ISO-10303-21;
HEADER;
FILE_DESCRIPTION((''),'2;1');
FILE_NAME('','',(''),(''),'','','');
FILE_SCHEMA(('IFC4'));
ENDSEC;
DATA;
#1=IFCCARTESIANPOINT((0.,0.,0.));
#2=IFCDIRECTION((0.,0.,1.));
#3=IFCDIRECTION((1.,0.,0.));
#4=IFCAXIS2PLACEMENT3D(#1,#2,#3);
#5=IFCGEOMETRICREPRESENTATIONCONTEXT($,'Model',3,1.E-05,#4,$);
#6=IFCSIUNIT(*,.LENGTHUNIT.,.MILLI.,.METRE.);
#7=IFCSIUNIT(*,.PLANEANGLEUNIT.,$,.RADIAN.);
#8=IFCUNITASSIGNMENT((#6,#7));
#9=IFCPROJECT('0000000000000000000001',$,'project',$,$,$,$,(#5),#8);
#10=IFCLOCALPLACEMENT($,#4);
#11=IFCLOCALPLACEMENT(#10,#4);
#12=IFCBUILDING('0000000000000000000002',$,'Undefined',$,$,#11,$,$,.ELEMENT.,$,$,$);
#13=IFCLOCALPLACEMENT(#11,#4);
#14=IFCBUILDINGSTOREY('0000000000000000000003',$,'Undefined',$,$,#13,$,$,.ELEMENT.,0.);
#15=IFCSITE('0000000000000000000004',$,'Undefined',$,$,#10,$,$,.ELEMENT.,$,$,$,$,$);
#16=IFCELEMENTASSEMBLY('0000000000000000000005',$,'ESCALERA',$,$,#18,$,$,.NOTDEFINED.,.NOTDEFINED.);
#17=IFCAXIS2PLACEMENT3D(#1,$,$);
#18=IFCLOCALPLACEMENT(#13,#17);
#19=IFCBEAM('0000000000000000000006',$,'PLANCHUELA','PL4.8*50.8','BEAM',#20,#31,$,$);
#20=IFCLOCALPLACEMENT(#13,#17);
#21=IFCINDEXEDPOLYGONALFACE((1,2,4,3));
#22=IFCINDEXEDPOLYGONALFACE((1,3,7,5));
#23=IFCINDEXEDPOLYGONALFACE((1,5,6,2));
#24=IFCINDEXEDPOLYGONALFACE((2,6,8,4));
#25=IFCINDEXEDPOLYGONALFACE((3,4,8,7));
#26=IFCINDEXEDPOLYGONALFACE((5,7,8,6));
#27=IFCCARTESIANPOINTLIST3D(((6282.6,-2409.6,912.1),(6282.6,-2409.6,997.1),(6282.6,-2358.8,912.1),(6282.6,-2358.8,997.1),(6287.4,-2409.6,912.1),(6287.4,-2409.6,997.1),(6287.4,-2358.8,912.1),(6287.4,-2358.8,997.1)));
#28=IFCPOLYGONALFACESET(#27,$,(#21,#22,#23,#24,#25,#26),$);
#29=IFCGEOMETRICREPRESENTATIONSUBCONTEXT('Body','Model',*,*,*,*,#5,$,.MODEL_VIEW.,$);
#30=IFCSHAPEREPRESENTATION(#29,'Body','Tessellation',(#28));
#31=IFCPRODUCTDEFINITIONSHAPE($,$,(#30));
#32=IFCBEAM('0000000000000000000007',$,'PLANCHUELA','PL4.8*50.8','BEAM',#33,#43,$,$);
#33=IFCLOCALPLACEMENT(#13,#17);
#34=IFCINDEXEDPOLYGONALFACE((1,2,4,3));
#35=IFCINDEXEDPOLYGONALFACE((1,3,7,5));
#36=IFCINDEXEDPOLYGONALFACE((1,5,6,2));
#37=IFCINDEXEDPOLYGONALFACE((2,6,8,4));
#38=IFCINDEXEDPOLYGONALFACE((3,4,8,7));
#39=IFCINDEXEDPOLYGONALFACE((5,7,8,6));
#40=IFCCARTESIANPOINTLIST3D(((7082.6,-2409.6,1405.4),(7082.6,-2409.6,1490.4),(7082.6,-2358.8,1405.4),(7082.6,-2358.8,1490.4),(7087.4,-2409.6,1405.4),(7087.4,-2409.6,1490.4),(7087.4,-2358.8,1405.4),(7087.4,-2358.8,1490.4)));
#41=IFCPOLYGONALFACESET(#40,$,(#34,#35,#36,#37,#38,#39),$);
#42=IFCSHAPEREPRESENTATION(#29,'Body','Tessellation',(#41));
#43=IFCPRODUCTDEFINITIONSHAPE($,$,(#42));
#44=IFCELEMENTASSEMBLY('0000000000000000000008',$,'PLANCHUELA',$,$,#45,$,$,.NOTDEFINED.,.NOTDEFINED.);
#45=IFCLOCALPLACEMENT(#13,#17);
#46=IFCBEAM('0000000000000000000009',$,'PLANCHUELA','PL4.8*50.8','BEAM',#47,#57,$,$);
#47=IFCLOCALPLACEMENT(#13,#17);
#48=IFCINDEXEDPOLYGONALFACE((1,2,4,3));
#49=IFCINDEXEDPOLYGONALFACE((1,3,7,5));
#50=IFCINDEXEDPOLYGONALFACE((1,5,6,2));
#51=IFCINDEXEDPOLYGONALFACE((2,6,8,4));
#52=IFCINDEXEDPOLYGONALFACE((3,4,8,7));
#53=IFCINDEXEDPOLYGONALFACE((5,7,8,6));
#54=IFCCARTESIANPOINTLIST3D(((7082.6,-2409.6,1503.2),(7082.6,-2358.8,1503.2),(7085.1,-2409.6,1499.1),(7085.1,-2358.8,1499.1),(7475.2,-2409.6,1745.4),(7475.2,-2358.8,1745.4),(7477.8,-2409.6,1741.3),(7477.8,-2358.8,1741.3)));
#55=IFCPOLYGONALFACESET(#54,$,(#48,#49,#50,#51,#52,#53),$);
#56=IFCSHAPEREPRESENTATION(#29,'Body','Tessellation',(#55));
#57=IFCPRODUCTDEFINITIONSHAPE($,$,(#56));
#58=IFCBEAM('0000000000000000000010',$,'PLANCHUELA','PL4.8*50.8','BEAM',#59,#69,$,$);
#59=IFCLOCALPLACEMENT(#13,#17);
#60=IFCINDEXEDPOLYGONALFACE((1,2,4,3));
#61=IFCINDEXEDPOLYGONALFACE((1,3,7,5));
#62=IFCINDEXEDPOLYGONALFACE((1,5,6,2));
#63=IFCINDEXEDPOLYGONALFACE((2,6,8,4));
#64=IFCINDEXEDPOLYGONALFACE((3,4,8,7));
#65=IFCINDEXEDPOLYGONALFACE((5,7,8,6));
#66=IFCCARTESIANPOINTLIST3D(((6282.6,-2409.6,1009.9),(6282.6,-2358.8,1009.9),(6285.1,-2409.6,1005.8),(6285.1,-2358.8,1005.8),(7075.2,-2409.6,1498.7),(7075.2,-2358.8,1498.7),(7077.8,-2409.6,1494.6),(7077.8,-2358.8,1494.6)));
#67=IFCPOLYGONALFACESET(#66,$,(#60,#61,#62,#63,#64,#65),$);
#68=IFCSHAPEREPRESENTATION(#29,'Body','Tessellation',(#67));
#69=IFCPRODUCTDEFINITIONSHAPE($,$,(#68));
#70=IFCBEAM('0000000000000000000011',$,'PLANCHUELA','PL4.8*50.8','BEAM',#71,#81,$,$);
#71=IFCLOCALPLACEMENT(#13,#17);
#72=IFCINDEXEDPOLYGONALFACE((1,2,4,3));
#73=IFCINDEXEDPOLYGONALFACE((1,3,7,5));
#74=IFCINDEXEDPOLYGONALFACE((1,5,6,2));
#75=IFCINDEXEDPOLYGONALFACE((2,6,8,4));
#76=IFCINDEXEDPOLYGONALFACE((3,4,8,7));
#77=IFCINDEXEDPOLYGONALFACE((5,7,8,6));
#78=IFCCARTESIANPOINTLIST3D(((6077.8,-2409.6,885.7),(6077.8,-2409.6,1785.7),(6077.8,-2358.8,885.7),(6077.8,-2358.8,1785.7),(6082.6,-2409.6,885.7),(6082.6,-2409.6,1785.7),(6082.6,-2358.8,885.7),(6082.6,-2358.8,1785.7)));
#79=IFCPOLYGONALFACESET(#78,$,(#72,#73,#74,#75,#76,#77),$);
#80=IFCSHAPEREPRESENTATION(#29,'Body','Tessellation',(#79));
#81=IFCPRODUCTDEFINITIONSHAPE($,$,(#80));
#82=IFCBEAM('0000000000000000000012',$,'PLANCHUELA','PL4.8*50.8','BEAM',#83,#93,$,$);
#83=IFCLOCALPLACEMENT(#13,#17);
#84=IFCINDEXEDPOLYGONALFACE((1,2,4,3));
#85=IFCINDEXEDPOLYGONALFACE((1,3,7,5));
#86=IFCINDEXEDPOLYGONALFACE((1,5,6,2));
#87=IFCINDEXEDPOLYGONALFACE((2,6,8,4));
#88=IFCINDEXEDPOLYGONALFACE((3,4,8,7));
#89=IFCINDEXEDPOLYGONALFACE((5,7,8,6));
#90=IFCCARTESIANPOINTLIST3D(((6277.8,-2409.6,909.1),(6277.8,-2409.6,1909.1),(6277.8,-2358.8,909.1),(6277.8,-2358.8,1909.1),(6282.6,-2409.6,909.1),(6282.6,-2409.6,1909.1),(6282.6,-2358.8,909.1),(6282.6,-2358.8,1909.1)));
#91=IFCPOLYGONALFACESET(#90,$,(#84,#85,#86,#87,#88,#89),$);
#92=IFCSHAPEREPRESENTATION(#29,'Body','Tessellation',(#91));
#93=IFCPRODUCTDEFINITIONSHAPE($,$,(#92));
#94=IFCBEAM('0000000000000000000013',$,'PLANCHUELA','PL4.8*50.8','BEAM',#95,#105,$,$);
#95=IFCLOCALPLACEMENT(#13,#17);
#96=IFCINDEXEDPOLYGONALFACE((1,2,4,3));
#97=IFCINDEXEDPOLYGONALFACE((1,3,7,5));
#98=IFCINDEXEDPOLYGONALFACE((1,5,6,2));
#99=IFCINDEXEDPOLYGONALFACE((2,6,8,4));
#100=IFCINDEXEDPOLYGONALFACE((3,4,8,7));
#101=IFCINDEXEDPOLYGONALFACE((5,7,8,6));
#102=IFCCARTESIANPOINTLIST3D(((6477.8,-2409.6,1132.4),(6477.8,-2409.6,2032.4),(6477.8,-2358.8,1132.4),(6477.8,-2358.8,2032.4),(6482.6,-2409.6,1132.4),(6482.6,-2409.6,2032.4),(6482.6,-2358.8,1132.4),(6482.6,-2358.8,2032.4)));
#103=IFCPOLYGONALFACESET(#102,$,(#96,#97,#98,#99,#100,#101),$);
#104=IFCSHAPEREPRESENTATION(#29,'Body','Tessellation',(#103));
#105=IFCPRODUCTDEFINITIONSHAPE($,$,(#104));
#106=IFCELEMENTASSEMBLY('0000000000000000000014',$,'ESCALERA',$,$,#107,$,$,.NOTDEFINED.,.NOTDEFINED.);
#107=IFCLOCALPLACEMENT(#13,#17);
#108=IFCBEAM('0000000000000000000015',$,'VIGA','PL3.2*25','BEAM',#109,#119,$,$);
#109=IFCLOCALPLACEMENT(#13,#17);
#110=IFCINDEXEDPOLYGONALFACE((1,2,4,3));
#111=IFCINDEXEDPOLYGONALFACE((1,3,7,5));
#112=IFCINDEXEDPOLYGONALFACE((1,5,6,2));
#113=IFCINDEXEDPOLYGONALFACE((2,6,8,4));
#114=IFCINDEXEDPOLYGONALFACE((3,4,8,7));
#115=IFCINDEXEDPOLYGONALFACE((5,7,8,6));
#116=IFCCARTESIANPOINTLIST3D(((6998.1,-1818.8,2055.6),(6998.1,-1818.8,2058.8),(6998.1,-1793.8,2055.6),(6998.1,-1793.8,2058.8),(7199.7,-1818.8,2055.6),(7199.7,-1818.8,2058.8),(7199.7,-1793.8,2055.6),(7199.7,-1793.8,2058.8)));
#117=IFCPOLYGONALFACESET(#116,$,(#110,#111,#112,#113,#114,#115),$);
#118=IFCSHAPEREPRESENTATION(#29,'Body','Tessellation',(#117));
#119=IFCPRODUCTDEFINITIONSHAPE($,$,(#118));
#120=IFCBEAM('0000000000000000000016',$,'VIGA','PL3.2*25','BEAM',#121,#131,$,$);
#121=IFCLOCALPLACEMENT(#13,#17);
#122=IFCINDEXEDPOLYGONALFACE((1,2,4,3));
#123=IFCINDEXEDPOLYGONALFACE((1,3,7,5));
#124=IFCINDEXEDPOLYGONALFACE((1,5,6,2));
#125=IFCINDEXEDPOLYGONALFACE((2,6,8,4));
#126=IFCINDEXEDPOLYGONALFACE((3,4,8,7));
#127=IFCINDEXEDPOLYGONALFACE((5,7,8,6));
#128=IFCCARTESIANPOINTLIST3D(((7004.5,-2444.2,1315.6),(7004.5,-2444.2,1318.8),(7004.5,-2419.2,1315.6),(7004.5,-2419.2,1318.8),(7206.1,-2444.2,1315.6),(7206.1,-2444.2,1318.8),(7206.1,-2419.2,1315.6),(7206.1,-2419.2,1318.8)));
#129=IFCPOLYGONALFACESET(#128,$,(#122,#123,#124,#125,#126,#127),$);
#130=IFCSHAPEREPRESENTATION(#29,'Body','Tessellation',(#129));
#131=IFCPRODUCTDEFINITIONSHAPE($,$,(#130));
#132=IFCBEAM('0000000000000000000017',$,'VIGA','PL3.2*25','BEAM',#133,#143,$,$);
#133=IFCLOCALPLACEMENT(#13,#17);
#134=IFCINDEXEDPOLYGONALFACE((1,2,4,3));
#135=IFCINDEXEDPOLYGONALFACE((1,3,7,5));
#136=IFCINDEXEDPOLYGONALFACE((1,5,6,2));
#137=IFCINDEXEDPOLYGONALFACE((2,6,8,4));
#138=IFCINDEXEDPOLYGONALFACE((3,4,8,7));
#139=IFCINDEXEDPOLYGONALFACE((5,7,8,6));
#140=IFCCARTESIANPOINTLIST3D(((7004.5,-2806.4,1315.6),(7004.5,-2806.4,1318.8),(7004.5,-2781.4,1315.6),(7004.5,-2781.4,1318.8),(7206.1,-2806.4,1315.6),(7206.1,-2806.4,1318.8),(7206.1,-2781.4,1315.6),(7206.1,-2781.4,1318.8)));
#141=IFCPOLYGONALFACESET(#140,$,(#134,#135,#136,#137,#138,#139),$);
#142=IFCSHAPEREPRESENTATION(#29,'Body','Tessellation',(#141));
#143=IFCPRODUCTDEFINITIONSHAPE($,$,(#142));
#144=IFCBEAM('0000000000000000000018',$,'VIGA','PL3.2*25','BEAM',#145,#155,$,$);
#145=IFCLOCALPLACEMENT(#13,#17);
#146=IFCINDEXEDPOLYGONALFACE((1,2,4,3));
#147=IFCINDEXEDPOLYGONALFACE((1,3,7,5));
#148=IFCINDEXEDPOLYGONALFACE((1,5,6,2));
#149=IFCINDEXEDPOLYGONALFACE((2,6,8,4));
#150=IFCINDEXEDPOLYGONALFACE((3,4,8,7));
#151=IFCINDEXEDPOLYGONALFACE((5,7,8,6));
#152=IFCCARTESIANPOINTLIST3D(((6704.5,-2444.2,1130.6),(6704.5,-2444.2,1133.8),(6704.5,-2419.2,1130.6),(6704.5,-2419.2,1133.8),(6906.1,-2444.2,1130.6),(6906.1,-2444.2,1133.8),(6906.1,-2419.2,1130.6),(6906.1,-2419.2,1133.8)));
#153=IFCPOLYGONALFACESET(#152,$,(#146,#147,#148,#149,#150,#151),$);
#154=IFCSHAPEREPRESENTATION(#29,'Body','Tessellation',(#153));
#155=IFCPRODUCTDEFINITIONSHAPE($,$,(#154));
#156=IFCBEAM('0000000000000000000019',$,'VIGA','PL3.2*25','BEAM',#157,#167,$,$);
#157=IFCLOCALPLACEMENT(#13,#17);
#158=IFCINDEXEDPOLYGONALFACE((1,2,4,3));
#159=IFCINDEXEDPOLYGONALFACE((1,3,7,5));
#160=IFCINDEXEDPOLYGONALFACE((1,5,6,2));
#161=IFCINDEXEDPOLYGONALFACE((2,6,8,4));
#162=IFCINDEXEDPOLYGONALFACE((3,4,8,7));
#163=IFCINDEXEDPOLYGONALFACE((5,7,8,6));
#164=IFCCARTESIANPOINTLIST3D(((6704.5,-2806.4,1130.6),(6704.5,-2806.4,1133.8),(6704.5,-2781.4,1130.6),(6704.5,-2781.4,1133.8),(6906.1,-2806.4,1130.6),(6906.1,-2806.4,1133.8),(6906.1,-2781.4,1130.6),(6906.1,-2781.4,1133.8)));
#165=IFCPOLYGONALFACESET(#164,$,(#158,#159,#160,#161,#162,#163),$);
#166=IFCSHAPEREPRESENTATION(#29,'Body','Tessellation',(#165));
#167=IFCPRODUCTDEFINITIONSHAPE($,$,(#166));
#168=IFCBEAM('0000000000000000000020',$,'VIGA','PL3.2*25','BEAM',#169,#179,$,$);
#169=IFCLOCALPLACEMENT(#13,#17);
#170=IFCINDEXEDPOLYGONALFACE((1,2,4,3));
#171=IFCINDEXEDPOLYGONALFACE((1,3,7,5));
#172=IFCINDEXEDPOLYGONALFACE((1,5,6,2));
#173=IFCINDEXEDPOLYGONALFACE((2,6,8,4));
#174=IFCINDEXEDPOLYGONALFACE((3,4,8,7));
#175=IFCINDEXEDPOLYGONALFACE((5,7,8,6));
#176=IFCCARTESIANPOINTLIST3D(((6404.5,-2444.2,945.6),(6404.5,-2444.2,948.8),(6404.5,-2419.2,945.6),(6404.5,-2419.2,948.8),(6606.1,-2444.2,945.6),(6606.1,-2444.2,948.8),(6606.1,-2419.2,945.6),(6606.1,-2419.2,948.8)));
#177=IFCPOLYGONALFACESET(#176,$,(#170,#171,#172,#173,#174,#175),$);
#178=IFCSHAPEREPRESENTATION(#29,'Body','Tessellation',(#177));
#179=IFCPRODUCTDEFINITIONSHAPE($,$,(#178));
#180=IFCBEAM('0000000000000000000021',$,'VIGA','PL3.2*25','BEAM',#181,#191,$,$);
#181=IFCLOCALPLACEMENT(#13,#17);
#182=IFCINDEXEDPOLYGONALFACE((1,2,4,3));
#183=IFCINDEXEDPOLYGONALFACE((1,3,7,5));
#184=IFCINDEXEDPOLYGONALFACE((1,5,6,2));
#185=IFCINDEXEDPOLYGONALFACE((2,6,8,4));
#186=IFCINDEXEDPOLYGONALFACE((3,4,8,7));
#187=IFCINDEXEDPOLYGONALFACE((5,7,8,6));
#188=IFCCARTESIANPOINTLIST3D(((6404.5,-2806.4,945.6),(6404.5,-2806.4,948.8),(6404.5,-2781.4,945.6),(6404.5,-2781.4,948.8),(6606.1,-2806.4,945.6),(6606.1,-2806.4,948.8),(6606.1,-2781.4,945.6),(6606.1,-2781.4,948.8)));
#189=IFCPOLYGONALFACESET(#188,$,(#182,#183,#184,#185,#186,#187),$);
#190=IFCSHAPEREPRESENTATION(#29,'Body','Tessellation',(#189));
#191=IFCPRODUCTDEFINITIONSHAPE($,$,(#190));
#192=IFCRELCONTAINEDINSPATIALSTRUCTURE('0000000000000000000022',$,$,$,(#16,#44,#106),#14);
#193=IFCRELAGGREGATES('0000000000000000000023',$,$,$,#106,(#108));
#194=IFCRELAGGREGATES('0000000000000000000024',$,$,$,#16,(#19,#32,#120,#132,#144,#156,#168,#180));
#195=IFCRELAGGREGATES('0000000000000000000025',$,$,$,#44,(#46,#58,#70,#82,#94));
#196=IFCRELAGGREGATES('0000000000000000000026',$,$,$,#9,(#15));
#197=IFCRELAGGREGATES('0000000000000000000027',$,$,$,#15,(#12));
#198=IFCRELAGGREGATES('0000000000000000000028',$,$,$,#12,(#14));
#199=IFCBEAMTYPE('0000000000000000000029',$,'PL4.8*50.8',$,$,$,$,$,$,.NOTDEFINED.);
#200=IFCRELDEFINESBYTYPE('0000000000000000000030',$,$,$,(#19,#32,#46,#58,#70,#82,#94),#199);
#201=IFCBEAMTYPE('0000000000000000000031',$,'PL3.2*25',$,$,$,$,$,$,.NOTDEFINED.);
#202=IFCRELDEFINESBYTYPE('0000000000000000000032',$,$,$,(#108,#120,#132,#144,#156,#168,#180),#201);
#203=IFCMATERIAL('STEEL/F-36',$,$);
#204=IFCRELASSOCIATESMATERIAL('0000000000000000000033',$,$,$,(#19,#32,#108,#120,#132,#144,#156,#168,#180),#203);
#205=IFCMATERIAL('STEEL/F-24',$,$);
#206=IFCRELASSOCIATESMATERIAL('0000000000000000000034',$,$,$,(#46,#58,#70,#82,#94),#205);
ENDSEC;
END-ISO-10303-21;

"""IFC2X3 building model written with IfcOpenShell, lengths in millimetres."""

from ifc_helpers import new_model, si_unit, frame, origin_with_axes, origin_2d_with_axis, place, context, subcontext, project, spatial, rectangle, extrude, material, type_object, element, aggregate, save


model = new_model("IFC2X3")

# Units and contexts
model_context = context("Model", 3, precision=1e-05, world=origin_with_axes())
body_context = subcontext(model_context, "Body", "Model", "MODEL_VIEW")
ifc_project = project(units=[si_unit("LENGTHUNIT", "METRE", prefix="MILLI"), si_unit("PLANEANGLEUNIT", "RADIAN")], contexts=[model_context])

# Site, building, storey
site_placement = place(None, origin_with_axes())
site = spatial("IfcSite", under=ifc_project, at=site_placement, Name="Undefined", CompositionType="ELEMENT")
building_placement = place(site_placement, origin_with_axes())
building = spatial("IfcBuilding", under=site, at=building_placement, Name="Undefined", CompositionType="ELEMENT")
storey_placement = place(building_placement, origin_with_axes())
storey = spatial("IfcBuildingStorey", under=building, at=storey_placement, Name="Undefined", CompositionType="ELEMENT", Elevation=0.0)

# Element assemblies, beams
assembly_1_placement = place(storey_placement, origin_with_axes())
assembly_1 = element("IfcElementAssembly", 1, at=assembly_1_placement, inside=storey, Name="ESCALERA", AssemblyPlace="NOTDEFINED", PredefinedType="NOTDEFINED")
ifc_material_1 = material(Name="STEEL/F-36")
beam_type_1 = type_object("IfcBeamType", Name="PL4.8*50.8", PredefinedType="NOTDEFINED")
beam_1_placement = place(assembly_1_placement, frame((6285.0, -2384.2, 997.1), z_axis=(0.0, -1.0, 0.0), x_axis=(0.0, 0.0, -1.0)))
beam_1 = element("IfcBeam", 2, at=beam_1_placement, type_object=beam_type_1, material=ifc_material_1, Name="PLANCHUELA", Description="PL4.8*50.8", ObjectType="BEAM", context=body_context, shape_type="SweptSolid", body=[
    extrude(rectangle(XDim=4.8, YDim=50.8, at=origin_2d_with_axis()), frame((85.0, 0.0, 0.0), z_axis=(-1.0, 0.0, 0.0), x_axis=(0.0, -1.0, 0.0)), (0.0, 0.0, 1.0), 85.0),
])
beam_2_placement = place(assembly_1_placement, frame((7085.0, -2384.2, 1490.4), z_axis=(0.0, -1.0, 0.0), x_axis=(0.0, 0.0, -1.0)))
beam_2 = element("IfcBeam", 3, at=beam_2_placement, type_object=beam_type_1, material=ifc_material_1, Name="PLANCHUELA", Description="PL4.8*50.8", ObjectType="BEAM", context=body_context, shape_type="SweptSolid", body=[
    extrude(rectangle(XDim=4.8, YDim=50.8, at=origin_2d_with_axis()), frame((85.0, 0.0, 0.0), z_axis=(-1.0, 0.0, 0.0), x_axis=(0.0, -1.0, 0.0)), (0.0, 0.0, 1.0), 85.0),
])
assembly_2_placement = place(storey_placement, origin_with_axes())
assembly_2 = element("IfcElementAssembly", 4, at=assembly_2_placement, inside=storey, Name="PLANCHUELA", AssemblyPlace="NOTDEFINED", PredefinedType="NOTDEFINED")
ifc_material_2 = material(Name="STEEL/F-24")
beam_3_placement = place(assembly_2_placement, frame((7083.8, -2384.2, 1501.2), z_axis=(0.0, -1.0, 0.0), x_axis=(0.85117, 0.0, 0.52489)))
beam_3 = element("IfcBeam", 5, at=beam_3_placement, type_object=beam_type_1, material=ifc_material_2, Name="PLANCHUELA", Description="PL4.8*50.8", ObjectType="BEAM", context=body_context, shape_type="SweptSolid", body=[
    extrude(rectangle(XDim=4.8, YDim=50.8, at=origin_2d_with_axis()), frame((461.3, 0.0, 0.0), z_axis=(-1.0, 0.0, 0.0), x_axis=(0.0, -1.0, 0.0)), (0.0, 0.0, 1.0), 461.3),
])
beam_4_placement = place(assembly_2_placement, frame((6283.8, -2384.2, 1007.9), z_axis=(0.0, -1.0, 0.0), x_axis=(0.85117, 0.0, 0.52489)))
beam_4 = element("IfcBeam", 6, at=beam_4_placement, type_object=beam_type_1, material=ifc_material_2, Name="PLANCHUELA", Description="PL4.8*50.8", ObjectType="BEAM", context=body_context, shape_type="SweptSolid", body=[
    extrude(rectangle(XDim=4.8, YDim=50.8, at=origin_2d_with_axis()), frame((931.3, 0.0, 0.0), z_axis=(-1.0, 0.0, 0.0), x_axis=(0.0, -1.0, 0.0)), (0.0, 0.0, 1.0), 931.3),
])
beam_5_placement = place(assembly_2_placement, frame((6080.2, -2384.2, 1785.7), z_axis=(0.0, -1.0, 0.0), x_axis=(0.0, 0.0, -1.0)))
beam_5 = element("IfcBeam", 7, at=beam_5_placement, type_object=beam_type_1, material=ifc_material_2, Name="PLANCHUELA", Description="PL4.8*50.8", ObjectType="BEAM", context=body_context, shape_type="SweptSolid", body=[
    extrude(rectangle(XDim=4.8, YDim=50.8, at=origin_2d_with_axis()), frame((900.0, 0.0, 0.0), z_axis=(-1.0, 0.0, 0.0), x_axis=(0.0, -1.0, 0.0)), (0.0, 0.0, 1.0), 900.0),
])
beam_6_placement = place(assembly_2_placement, frame((6280.2, -2384.2, 1909.1), z_axis=(0.0, -1.0, 0.0), x_axis=(0.0, 0.0, -1.0)))
beam_6 = element("IfcBeam", 8, at=beam_6_placement, type_object=beam_type_1, material=ifc_material_2, Name="PLANCHUELA", Description="PL4.8*50.8", ObjectType="BEAM", context=body_context, shape_type="SweptSolid", body=[
    extrude(rectangle(XDim=4.8, YDim=50.8, at=origin_2d_with_axis()), frame((1000.0, 0.0, 0.0), z_axis=(-1.0, 0.0, 0.0), x_axis=(0.0, -1.0, 0.0)), (0.0, 0.0, 1.0), 1000.0),
])
beam_7_placement = place(assembly_2_placement, frame((6480.2, -2384.2, 2032.4), z_axis=(0.0, -1.0, 0.0), x_axis=(0.0, 0.0, -1.0)))
beam_7 = element("IfcBeam", 9, at=beam_7_placement, type_object=beam_type_1, material=ifc_material_2, Name="PLANCHUELA", Description="PL4.8*50.8", ObjectType="BEAM", context=body_context, shape_type="SweptSolid", body=[
    extrude(rectangle(XDim=4.8, YDim=50.8, at=origin_2d_with_axis()), frame((900.0, 0.0, 0.0), z_axis=(-1.0, 0.0, 0.0), x_axis=(0.0, -1.0, 0.0)), (0.0, 0.0, 1.0), 900.0),
])

# Element assembly, beam
assembly_3_placement = place(storey_placement, origin_with_axes())
assembly_3 = element("IfcElementAssembly", 10, at=assembly_3_placement, inside=storey, Name="ESCALERA", AssemblyPlace="NOTDEFINED", PredefinedType="NOTDEFINED")
beam_type_2 = type_object("IfcBeamType", Name="PL3.2*25", PredefinedType="NOTDEFINED")
beam_8_placement = place(assembly_3_placement, frame((7199.7, -1806.3, 2057.2), z_axis=(0.0, 1.0, 0.0), x_axis=(-1.0, 0.0, 0.000012)))
beam_8 = element("IfcBeam", 11, at=beam_8_placement, type_object=beam_type_2, material=ifc_material_1, Name="VIGA", Description="PL3.2*25", ObjectType="BEAM", context=body_context, shape_type="SweptSolid", body=[
    extrude(rectangle(XDim=3.2, YDim=25.0, at=origin_2d_with_axis()), frame((201.6, 0.0, 0.0), z_axis=(-1.0, 0.0, 0.0), x_axis=(0.0, -1.0, 0.0)), (0.0, 0.0, 1.0), 201.6),
])

# Beams
beam_9_placement = place(assembly_1_placement, frame((7004.5, -2431.7, 1317.2), z_axis=(0.0, 1.0, 0.0), x_axis=(1.0, 0.0, 0.000012)))
beam_9 = element("IfcBeam", 12, at=beam_9_placement, type_object=beam_type_2, material=ifc_material_1, Name="VIGA", Description="PL3.2*25", ObjectType="BEAM", context=body_context, shape_type="SweptSolid", body=[
    extrude(rectangle(XDim=3.2, YDim=25.0, at=origin_2d_with_axis()), frame((201.6, 0.0, 0.0), z_axis=(-1.0, 0.0, 0.0), x_axis=(0.0, -1.0, 0.0)), (0.0, 0.0, 1.0), 201.6),
])
beam_10_placement = place(assembly_1_placement, frame((7004.5, -2793.9, 1317.2), z_axis=(0.0, 1.0, 0.0), x_axis=(1.0, 0.0, 0.000012)))
beam_10 = element("IfcBeam", 13, at=beam_10_placement, type_object=beam_type_2, material=ifc_material_1, Name="VIGA", Description="PL3.2*25", ObjectType="BEAM", context=body_context, shape_type="SweptSolid", body=[
    extrude(rectangle(XDim=3.2, YDim=25.0, at=origin_2d_with_axis()), frame((201.6, 0.0, 0.0), z_axis=(-1.0, 0.0, 0.0), x_axis=(0.0, -1.0, 0.0)), (0.0, 0.0, 1.0), 201.6),
])
beam_11_placement = place(assembly_1_placement, frame((6704.5, -2431.7, 1132.2), z_axis=(0.0, 1.0, 0.0), x_axis=(1.0, 0.0, 0.000012)))
beam_11 = element("IfcBeam", 14, at=beam_11_placement, type_object=beam_type_2, material=ifc_material_1, Name="VIGA", Description="PL3.2*25", ObjectType="BEAM", context=body_context, shape_type="SweptSolid", body=[
    extrude(rectangle(XDim=3.2, YDim=25.0, at=origin_2d_with_axis()), frame((201.6, 0.0, 0.0), z_axis=(-1.0, 0.0, 0.0), x_axis=(0.0, -1.0, 0.0)), (0.0, 0.0, 1.0), 201.6),
])
beam_12_placement = place(assembly_1_placement, frame((6704.5, -2793.9, 1132.2), z_axis=(0.0, 1.0, 0.0), x_axis=(1.0, 0.0, 0.000012)))
beam_12 = element("IfcBeam", 15, at=beam_12_placement, type_object=beam_type_2, material=ifc_material_1, Name="VIGA", Description="PL3.2*25", ObjectType="BEAM", context=body_context, shape_type="SweptSolid", body=[
    extrude(rectangle(XDim=3.2, YDim=25.0, at=origin_2d_with_axis()), frame((201.6, 0.0, 0.0), z_axis=(-1.0, 0.0, 0.0), x_axis=(0.0, -1.0, 0.0)), (0.0, 0.0, 1.0), 201.6),
])
beam_13_placement = place(assembly_1_placement, frame((6404.5, -2431.7, 947.2), z_axis=(0.0, 1.0, 0.0), x_axis=(1.0, 0.0, 0.000012)))
beam_13 = element("IfcBeam", 16, at=beam_13_placement, type_object=beam_type_2, material=ifc_material_1, Name="VIGA", Description="PL3.2*25", ObjectType="BEAM", context=body_context, shape_type="SweptSolid", body=[
    extrude(rectangle(XDim=3.2, YDim=25.0, at=origin_2d_with_axis()), frame((201.6, 0.0, 0.0), z_axis=(-1.0, 0.0, 0.0), x_axis=(0.0, -1.0, 0.0)), (0.0, 0.0, 1.0), 201.6),
])
beam_14_placement = place(assembly_1_placement, frame((6404.5, -2793.9, 947.2), z_axis=(0.0, 1.0, 0.0), x_axis=(1.0, 0.0, 0.000012)))
beam_14 = element("IfcBeam", 17, at=beam_14_placement, type_object=beam_type_2, material=ifc_material_1, Name="VIGA", Description="PL3.2*25", ObjectType="BEAM", context=body_context, shape_type="SweptSolid", body=[
    extrude(rectangle(XDim=3.2, YDim=25.0, at=origin_2d_with_axis()), frame((201.6, 0.0, 0.0), z_axis=(-1.0, 0.0, 0.0), x_axis=(0.0, -1.0, 0.0)), (0.0, 0.0, 1.0), 201.6),
])

aggregate(assembly_3, [beam_8])
aggregate(assembly_1, [beam_1, beam_2, beam_9, beam_10, beam_11, beam_12, beam_13, beam_14])

aggregate(assembly_2, [beam_3, beam_4, beam_5, beam_6, beam_7])

save(model, "model.ifc")
